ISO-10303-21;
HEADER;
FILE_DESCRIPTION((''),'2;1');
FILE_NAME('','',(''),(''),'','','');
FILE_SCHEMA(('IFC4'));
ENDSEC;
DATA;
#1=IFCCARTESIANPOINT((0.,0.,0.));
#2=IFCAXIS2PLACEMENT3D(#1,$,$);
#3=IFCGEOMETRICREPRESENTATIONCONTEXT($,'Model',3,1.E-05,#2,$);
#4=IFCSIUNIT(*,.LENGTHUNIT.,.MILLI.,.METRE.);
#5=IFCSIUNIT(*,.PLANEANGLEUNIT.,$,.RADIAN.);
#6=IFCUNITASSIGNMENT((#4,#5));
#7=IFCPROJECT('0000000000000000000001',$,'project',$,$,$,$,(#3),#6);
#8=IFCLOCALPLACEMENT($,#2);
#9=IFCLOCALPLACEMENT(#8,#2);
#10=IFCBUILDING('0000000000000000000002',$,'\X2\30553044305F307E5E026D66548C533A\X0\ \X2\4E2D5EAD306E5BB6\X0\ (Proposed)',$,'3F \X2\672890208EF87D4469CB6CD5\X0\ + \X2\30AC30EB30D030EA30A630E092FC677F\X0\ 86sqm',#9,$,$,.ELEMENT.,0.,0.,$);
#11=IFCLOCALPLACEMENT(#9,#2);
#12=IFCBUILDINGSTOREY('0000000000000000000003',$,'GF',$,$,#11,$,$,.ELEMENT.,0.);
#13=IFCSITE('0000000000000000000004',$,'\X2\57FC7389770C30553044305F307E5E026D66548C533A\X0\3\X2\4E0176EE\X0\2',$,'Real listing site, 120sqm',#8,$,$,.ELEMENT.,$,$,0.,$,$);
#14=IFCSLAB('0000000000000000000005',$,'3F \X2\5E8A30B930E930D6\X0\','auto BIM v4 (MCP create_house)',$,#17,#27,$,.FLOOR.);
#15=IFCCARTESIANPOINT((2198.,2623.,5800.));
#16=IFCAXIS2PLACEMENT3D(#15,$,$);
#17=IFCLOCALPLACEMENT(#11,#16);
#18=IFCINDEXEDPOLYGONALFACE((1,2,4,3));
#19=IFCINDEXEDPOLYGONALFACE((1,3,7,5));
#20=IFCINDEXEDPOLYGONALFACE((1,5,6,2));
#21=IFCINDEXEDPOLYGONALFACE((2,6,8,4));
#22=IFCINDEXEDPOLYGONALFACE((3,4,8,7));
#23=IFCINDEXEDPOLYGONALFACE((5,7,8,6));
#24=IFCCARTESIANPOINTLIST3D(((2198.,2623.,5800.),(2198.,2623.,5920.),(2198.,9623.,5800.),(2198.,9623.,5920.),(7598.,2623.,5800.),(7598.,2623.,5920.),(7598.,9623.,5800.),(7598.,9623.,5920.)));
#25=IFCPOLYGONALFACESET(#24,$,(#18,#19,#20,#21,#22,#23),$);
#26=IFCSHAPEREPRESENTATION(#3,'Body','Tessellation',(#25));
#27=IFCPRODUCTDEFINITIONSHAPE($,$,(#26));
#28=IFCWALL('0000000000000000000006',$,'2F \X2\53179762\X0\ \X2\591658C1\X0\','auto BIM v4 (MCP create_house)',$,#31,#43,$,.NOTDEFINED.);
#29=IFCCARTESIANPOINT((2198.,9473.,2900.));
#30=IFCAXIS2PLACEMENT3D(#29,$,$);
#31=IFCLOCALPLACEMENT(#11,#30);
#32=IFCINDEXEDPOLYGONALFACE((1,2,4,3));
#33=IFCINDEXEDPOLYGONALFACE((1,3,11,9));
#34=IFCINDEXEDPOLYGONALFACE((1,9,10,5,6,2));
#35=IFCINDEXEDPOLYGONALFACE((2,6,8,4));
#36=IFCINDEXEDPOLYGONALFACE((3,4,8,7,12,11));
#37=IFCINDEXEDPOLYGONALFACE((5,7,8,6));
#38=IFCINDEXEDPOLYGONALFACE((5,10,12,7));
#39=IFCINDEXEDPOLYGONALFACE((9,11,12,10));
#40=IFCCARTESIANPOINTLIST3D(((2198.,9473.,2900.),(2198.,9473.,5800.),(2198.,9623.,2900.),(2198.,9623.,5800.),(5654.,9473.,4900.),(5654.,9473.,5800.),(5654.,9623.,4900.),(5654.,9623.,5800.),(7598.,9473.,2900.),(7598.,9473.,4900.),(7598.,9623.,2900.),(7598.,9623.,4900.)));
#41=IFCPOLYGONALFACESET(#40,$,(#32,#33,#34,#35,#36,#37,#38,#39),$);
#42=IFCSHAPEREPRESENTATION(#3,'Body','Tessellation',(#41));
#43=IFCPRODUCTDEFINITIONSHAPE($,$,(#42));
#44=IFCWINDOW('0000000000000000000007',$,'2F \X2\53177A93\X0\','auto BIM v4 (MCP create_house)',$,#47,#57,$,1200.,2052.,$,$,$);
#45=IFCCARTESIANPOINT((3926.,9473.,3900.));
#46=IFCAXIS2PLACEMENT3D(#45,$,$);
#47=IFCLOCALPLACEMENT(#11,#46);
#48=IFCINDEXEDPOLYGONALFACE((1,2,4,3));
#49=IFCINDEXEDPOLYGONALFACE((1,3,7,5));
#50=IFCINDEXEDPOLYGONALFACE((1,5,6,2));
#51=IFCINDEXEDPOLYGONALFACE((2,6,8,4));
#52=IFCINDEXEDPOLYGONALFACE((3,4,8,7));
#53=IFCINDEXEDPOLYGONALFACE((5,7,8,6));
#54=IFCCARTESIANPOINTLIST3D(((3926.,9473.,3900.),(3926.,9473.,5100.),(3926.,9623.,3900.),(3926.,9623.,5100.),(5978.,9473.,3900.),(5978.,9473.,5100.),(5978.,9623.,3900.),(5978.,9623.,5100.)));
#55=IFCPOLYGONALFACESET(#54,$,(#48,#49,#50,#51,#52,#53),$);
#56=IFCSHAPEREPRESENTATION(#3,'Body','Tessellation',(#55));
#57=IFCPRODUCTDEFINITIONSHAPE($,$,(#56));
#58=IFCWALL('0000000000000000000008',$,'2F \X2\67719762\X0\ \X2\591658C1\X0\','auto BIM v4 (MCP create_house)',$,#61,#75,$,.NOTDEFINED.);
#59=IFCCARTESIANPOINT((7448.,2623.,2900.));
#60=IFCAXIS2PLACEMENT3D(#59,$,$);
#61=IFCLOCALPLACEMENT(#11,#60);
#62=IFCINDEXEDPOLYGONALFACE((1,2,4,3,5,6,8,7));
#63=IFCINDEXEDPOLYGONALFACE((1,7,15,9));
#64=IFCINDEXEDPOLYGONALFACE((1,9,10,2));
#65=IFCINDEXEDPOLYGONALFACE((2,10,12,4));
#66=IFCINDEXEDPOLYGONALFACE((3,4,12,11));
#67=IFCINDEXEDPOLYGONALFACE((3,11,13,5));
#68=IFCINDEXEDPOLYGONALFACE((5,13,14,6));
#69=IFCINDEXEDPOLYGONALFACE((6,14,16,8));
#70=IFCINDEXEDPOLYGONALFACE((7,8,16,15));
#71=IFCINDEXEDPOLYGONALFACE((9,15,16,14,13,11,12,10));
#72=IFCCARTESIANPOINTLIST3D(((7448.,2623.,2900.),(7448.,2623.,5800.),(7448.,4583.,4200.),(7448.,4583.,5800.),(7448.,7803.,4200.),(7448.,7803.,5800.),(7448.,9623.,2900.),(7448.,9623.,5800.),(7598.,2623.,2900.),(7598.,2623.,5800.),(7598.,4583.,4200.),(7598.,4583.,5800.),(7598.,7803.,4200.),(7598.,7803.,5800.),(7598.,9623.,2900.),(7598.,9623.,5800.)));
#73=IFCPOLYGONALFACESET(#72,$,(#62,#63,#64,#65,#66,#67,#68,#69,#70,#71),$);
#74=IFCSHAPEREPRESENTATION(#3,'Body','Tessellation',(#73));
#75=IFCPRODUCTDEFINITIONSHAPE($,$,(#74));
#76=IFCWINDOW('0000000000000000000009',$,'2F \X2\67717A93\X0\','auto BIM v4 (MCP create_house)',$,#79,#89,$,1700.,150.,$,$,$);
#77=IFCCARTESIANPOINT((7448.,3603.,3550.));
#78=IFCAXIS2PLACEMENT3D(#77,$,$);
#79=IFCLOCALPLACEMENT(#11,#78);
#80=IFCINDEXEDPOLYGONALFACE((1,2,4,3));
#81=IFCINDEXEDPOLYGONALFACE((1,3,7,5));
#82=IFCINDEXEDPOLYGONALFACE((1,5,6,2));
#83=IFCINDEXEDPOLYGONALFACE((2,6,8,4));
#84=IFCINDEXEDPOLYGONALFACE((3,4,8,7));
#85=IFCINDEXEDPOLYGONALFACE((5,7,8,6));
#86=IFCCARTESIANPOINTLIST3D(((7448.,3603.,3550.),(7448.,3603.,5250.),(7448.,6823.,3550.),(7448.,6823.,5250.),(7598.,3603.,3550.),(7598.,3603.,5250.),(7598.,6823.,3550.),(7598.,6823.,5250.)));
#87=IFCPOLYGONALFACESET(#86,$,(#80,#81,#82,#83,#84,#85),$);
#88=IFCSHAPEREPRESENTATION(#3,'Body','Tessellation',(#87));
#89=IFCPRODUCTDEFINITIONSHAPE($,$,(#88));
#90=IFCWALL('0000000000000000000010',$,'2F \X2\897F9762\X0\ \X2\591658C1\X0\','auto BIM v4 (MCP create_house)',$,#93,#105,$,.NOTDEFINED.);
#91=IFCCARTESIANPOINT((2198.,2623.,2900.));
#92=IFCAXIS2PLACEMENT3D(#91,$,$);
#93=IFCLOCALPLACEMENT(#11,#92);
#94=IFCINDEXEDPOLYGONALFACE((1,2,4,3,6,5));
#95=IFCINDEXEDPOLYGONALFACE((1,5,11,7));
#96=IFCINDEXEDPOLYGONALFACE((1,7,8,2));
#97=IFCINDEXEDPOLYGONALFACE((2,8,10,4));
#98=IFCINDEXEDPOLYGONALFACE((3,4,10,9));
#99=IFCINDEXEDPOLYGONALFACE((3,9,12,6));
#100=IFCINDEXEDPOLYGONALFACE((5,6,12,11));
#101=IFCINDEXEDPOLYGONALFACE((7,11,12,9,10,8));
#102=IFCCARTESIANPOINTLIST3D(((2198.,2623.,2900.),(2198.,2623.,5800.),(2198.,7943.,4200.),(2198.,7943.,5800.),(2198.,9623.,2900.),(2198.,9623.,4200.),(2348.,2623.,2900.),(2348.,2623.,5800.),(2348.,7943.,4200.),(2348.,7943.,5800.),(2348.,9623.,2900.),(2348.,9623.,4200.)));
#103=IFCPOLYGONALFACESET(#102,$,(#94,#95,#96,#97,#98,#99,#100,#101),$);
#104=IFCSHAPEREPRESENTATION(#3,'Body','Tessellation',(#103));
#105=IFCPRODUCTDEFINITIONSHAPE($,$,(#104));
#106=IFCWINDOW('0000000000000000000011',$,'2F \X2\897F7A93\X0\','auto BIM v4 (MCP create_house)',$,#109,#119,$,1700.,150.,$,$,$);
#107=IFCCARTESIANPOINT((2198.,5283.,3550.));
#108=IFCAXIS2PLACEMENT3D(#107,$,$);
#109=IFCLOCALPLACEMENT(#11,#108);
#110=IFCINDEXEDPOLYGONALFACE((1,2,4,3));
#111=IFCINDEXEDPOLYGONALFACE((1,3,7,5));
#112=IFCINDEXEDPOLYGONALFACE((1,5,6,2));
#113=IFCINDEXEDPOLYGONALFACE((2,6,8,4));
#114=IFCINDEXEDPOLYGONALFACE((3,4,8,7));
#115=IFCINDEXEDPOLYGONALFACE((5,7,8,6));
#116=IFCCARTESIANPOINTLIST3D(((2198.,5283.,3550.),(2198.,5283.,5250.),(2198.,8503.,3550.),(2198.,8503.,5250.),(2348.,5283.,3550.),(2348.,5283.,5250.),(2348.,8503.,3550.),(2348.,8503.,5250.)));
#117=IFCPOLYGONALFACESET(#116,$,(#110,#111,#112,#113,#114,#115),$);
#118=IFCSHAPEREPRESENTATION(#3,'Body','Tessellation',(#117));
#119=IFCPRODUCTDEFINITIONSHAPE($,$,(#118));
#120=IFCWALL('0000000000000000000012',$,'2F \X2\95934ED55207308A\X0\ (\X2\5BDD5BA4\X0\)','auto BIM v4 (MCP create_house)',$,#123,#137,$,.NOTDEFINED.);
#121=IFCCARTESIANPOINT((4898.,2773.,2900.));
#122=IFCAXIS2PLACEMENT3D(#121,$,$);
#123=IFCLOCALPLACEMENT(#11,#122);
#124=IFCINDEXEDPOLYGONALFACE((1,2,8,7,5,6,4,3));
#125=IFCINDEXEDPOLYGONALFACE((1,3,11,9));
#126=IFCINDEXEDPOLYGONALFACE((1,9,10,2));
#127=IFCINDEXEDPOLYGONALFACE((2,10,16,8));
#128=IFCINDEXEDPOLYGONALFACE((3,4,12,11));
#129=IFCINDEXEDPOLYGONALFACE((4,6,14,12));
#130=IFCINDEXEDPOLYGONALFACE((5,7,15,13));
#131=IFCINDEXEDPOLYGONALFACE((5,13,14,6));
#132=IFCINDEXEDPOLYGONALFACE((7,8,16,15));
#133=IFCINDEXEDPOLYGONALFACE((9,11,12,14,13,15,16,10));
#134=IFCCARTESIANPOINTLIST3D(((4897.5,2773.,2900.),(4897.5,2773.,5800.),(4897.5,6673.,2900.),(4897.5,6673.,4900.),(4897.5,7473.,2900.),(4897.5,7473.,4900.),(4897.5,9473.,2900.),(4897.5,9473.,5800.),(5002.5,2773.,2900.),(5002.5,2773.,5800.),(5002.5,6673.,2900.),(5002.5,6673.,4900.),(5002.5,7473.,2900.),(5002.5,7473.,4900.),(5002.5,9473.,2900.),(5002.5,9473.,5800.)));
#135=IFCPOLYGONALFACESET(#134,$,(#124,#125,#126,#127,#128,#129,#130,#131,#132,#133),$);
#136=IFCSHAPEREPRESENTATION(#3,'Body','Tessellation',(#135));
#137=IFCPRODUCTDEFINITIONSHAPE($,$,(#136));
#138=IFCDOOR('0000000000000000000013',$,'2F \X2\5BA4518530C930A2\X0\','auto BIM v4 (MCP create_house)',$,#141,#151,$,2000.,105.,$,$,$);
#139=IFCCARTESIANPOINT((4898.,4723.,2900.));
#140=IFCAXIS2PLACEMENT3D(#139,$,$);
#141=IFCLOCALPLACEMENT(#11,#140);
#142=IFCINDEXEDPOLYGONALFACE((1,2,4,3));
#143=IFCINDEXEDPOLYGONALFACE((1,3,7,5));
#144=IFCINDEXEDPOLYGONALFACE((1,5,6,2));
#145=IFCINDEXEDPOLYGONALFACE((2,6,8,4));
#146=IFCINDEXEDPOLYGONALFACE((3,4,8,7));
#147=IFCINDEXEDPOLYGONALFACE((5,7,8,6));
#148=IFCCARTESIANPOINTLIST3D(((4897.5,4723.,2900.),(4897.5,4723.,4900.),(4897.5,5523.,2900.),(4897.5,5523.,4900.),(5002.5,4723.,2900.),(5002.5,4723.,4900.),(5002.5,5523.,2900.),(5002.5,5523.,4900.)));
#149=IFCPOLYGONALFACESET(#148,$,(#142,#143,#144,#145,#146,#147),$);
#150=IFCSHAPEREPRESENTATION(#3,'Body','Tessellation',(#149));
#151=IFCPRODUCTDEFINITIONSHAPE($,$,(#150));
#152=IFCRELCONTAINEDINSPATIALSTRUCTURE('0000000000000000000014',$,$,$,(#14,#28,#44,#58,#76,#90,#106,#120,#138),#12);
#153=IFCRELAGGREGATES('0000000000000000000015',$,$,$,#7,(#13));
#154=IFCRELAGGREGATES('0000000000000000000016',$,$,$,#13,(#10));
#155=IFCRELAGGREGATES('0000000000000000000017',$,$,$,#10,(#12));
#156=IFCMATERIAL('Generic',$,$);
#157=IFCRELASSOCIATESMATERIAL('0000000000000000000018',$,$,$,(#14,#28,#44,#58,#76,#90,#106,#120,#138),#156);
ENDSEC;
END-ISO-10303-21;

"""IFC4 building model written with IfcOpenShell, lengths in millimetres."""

from ifc_helpers import new_model, si_unit, frame, frame_2d, origin, place, context, project, spatial, rectangle, extrude, material, element, fill, save


model = new_model("IFC4")

# Units and contexts
model_context = context("Model", 3, precision=1e-05, world=origin())
ifc_project = project(units=[si_unit("LENGTHUNIT", "METRE", prefix="MILLI"), si_unit("PLANEANGLEUNIT", "RADIAN")], contexts=[model_context])

# Site, building, storey
site_placement = place(None, origin())
site = spatial("IfcSite", under=ifc_project, at=site_placement, Name="埼玉県さいたま市浦和区3丁目2", ObjectType="Real listing site, 120sqm", CompositionType="ELEMENT", RefElevation=0.0)
building_placement = place(site_placement, origin())
building = spatial("IfcBuilding", under=site, at=building_placement, Name="さいたま市浦和区 中庭の家 (Proposed)", ObjectType="3F 木造軸組構法 + ガルバリウム鋼板 86sqm", CompositionType="ELEMENT", ElevationOfRefHeight=0.0, ElevationOfTerrain=0.0)
storey_placement = place(building_placement, origin())
storey = spatial("IfcBuildingStorey", under=building, at=storey_placement, Name="GF", CompositionType="ELEMENT", Elevation=0.0)

# Slab
ifc_material = material(Name="Generic")
slab_placement = place(storey_placement, frame((2198.0, 2623.0, 5800.0)))
element("IfcSlab", 1, at=slab_placement, inside=storey, material=ifc_material, Name="3F 床スラブ", Description="auto BIM v4 (MCP create_house)", PredefinedType="FLOOR", context=model_context, shape_type="SweptSolid", body=[
    extrude(rectangle(XDim=5400.0, YDim=7000.0, at=frame_2d((2700.0, 3500.0))), frame((2198.0, 2623.0, 5800.0)), (0.0, 0.0, 1.0), 120.0),
])

# Walls, openings, windows
wall_1_placement = place(storey_placement, frame((2198.0, 9473.0, 2900.0)))
wall_1 = element("IfcWall", 2, at=wall_1_placement, inside=storey, material=ifc_material, Name="2F 北面 外壁", Description="auto BIM v4 (MCP create_house)", PredefinedType="NOTDEFINED", context=model_context, shape_type="SweptSolid", body=[
    extrude(rectangle(XDim=5400.0, YDim=150.0, at=frame_2d((2700.0, 75.0))), frame((2198.0, 9473.0, 2900.0)), (0.0, 0.0, 1.0), 2900.0),
])
opening_1_placement = place(storey_placement, frame((3926.0, 9473.0, 3900.0)))
opening_1 = element("IfcOpeningElement", 3, at=opening_1_placement, cuts=wall_1, PredefinedType="NOTDEFINED", context=model_context, shape_type="SweptSolid", body=[
    extrude(rectangle(XDim=2052.0, YDim=150.0, at=frame_2d((1026.0, 75.0))), frame((3926.0, 9473.0, 3900.0)), (0.0, 0.0, 1.0), 1200.0),
])
window_1_placement = place(storey_placement, frame((3926.0, 9473.0, 3900.0)))
window_1 = element("IfcWindow", 4, at=window_1_placement, inside=storey, material=ifc_material, Name="2F 北窓", Description="auto BIM v4 (MCP create_house)", OverallHeight=1200.0, OverallWidth=2052.0, context=model_context, shape_type="SweptSolid", body=[
    extrude(rectangle(XDim=2052.0, YDim=150.0, at=frame_2d((1026.0, 75.0))), frame((3926.0, 9473.0, 3900.0)), (0.0, 0.0, 1.0), 1200.0),
])
fill(opening_1, window_1)
wall_2_placement = place(storey_placement, frame((7448.0, 2623.0, 2900.0)))
wall_2 = element("IfcWall", 5, at=wall_2_placement, inside=storey, material=ifc_material, Name="2F 東面 外壁", Description="auto BIM v4 (MCP create_house)", PredefinedType="NOTDEFINED", context=model_context, shape_type="SweptSolid", body=[
    extrude(rectangle(XDim=150.0, YDim=7000.0, at=frame_2d((75.0, 3500.0))), frame((7448.0, 2623.0, 2900.0)), (0.0, 0.0, 1.0), 2900.0),
])
opening_2_placement = place(storey_placement, frame((7448.0, 3603.0, 3550.0)))
opening_2 = element("IfcOpeningElement", 6, at=opening_2_placement, cuts=wall_2, PredefinedType="NOTDEFINED", context=model_context, shape_type="SweptSolid", body=[
    extrude(rectangle(XDim=150.0, YDim=3220.0, at=frame_2d((75.0, 1610.0))), frame((7448.0, 3603.0, 3550.0)), (0.0, 0.0, 1.0), 1700.0),
])
window_2_placement = place(storey_placement, frame((7448.0, 3603.0, 3550.0)))
window_2 = element("IfcWindow", 7, at=window_2_placement, inside=storey, material=ifc_material, Name="2F 東窓", Description="auto BIM v4 (MCP create_house)", OverallHeight=1700.0, OverallWidth=150.0, context=model_context, shape_type="SweptSolid", body=[
    extrude(rectangle(XDim=150.0, YDim=3220.0, at=frame_2d((75.0, 1610.0))), frame((7448.0, 3603.0, 3550.0)), (0.0, 0.0, 1.0), 1700.0),
])
fill(opening_2, window_2)
wall_3_placement = place(storey_placement, frame((2198.0, 2623.0, 2900.0)))
wall_3 = element("IfcWall", 8, at=wall_3_placement, inside=storey, material=ifc_material, Name="2F 西面 外壁", Description="auto BIM v4 (MCP create_house)", PredefinedType="NOTDEFINED", context=model_context, shape_type="SweptSolid", body=[
    extrude(rectangle(XDim=150.0, YDim=7000.0, at=frame_2d((75.0, 3500.0))), frame((2198.0, 2623.0, 2900.0)), (0.0, 0.0, 1.0), 2900.0),
])
opening_3_placement = place(storey_placement, frame((2198.0, 5283.0, 3550.0)))
opening_3 = element("IfcOpeningElement", 9, at=opening_3_placement, cuts=wall_3, PredefinedType="NOTDEFINED", context=model_context, shape_type="SweptSolid", body=[
    extrude(rectangle(XDim=150.0, YDim=3220.0, at=frame_2d((75.0, 1610.0))), frame((2198.0, 5283.0, 3550.0)), (0.0, 0.0, 1.0), 1700.0),
])
window_3_placement = place(storey_placement, frame((2198.0, 5283.0, 3550.0)))
window_3 = element("IfcWindow", 10, at=window_3_placement, inside=storey, material=ifc_material, Name="2F 西窓", Description="auto BIM v4 (MCP create_house)", OverallHeight=1700.0, OverallWidth=150.0, context=model_context, shape_type="SweptSolid", body=[
    extrude(rectangle(XDim=150.0, YDim=3220.0, at=frame_2d((75.0, 1610.0))), frame((2198.0, 5283.0, 3550.0)), (0.0, 0.0, 1.0), 1700.0),
])
fill(opening_3, window_3)

# Wall, opening, door
wall_4_placement = place(storey_placement, frame((4898.0, 2773.0, 2900.0)))
wall_4 = element("IfcWall", 11, at=wall_4_placement, inside=storey, material=ifc_material, Name="2F 間仕切り (寝室)", Description="auto BIM v4 (MCP create_house)", PredefinedType="NOTDEFINED", context=model_context, shape_type="SweptSolid", body=[
    extrude(rectangle(XDim=105.0, YDim=6700.0, at=frame_2d((52.0, 3350.0))), frame((4898.0, 2773.0, 2900.0)), (0.0, 0.0, 1.0), 2900.0),
])
opening_4_placement = place(storey_placement, frame((4898.0, 4723.0, 2900.0)))
opening_4 = element("IfcOpeningElement", 12, at=opening_4_placement, cuts=wall_4, PredefinedType="NOTDEFINED", context=model_context, shape_type="SweptSolid", body=[
    extrude(rectangle(XDim=105.0, YDim=800.0, at=frame_2d((52.0, 400.0))), frame((4898.0, 4723.0, 2900.0)), (0.0, 0.0, 1.0), 2000.0),
])
door_1_placement = place(storey_placement, frame((4898.0, 4723.0, 2900.0)))
door_1 = element("IfcDoor", 13, at=door_1_placement, inside=storey, material=ifc_material, Name="2F 室内ドア", Description="auto BIM v4 (MCP create_house)", OverallHeight=2000.0, OverallWidth=105.0, context=model_context, shape_type="SweptSolid", body=[
    extrude(rectangle(XDim=105.0, YDim=800.0, at=frame_2d((52.0, 400.0))), frame((4898.0, 4723.0, 2900.0)), (0.0, 0.0, 1.0), 2000.0),
])
fill(opening_4, door_1)

save(model, "model.ifc")
